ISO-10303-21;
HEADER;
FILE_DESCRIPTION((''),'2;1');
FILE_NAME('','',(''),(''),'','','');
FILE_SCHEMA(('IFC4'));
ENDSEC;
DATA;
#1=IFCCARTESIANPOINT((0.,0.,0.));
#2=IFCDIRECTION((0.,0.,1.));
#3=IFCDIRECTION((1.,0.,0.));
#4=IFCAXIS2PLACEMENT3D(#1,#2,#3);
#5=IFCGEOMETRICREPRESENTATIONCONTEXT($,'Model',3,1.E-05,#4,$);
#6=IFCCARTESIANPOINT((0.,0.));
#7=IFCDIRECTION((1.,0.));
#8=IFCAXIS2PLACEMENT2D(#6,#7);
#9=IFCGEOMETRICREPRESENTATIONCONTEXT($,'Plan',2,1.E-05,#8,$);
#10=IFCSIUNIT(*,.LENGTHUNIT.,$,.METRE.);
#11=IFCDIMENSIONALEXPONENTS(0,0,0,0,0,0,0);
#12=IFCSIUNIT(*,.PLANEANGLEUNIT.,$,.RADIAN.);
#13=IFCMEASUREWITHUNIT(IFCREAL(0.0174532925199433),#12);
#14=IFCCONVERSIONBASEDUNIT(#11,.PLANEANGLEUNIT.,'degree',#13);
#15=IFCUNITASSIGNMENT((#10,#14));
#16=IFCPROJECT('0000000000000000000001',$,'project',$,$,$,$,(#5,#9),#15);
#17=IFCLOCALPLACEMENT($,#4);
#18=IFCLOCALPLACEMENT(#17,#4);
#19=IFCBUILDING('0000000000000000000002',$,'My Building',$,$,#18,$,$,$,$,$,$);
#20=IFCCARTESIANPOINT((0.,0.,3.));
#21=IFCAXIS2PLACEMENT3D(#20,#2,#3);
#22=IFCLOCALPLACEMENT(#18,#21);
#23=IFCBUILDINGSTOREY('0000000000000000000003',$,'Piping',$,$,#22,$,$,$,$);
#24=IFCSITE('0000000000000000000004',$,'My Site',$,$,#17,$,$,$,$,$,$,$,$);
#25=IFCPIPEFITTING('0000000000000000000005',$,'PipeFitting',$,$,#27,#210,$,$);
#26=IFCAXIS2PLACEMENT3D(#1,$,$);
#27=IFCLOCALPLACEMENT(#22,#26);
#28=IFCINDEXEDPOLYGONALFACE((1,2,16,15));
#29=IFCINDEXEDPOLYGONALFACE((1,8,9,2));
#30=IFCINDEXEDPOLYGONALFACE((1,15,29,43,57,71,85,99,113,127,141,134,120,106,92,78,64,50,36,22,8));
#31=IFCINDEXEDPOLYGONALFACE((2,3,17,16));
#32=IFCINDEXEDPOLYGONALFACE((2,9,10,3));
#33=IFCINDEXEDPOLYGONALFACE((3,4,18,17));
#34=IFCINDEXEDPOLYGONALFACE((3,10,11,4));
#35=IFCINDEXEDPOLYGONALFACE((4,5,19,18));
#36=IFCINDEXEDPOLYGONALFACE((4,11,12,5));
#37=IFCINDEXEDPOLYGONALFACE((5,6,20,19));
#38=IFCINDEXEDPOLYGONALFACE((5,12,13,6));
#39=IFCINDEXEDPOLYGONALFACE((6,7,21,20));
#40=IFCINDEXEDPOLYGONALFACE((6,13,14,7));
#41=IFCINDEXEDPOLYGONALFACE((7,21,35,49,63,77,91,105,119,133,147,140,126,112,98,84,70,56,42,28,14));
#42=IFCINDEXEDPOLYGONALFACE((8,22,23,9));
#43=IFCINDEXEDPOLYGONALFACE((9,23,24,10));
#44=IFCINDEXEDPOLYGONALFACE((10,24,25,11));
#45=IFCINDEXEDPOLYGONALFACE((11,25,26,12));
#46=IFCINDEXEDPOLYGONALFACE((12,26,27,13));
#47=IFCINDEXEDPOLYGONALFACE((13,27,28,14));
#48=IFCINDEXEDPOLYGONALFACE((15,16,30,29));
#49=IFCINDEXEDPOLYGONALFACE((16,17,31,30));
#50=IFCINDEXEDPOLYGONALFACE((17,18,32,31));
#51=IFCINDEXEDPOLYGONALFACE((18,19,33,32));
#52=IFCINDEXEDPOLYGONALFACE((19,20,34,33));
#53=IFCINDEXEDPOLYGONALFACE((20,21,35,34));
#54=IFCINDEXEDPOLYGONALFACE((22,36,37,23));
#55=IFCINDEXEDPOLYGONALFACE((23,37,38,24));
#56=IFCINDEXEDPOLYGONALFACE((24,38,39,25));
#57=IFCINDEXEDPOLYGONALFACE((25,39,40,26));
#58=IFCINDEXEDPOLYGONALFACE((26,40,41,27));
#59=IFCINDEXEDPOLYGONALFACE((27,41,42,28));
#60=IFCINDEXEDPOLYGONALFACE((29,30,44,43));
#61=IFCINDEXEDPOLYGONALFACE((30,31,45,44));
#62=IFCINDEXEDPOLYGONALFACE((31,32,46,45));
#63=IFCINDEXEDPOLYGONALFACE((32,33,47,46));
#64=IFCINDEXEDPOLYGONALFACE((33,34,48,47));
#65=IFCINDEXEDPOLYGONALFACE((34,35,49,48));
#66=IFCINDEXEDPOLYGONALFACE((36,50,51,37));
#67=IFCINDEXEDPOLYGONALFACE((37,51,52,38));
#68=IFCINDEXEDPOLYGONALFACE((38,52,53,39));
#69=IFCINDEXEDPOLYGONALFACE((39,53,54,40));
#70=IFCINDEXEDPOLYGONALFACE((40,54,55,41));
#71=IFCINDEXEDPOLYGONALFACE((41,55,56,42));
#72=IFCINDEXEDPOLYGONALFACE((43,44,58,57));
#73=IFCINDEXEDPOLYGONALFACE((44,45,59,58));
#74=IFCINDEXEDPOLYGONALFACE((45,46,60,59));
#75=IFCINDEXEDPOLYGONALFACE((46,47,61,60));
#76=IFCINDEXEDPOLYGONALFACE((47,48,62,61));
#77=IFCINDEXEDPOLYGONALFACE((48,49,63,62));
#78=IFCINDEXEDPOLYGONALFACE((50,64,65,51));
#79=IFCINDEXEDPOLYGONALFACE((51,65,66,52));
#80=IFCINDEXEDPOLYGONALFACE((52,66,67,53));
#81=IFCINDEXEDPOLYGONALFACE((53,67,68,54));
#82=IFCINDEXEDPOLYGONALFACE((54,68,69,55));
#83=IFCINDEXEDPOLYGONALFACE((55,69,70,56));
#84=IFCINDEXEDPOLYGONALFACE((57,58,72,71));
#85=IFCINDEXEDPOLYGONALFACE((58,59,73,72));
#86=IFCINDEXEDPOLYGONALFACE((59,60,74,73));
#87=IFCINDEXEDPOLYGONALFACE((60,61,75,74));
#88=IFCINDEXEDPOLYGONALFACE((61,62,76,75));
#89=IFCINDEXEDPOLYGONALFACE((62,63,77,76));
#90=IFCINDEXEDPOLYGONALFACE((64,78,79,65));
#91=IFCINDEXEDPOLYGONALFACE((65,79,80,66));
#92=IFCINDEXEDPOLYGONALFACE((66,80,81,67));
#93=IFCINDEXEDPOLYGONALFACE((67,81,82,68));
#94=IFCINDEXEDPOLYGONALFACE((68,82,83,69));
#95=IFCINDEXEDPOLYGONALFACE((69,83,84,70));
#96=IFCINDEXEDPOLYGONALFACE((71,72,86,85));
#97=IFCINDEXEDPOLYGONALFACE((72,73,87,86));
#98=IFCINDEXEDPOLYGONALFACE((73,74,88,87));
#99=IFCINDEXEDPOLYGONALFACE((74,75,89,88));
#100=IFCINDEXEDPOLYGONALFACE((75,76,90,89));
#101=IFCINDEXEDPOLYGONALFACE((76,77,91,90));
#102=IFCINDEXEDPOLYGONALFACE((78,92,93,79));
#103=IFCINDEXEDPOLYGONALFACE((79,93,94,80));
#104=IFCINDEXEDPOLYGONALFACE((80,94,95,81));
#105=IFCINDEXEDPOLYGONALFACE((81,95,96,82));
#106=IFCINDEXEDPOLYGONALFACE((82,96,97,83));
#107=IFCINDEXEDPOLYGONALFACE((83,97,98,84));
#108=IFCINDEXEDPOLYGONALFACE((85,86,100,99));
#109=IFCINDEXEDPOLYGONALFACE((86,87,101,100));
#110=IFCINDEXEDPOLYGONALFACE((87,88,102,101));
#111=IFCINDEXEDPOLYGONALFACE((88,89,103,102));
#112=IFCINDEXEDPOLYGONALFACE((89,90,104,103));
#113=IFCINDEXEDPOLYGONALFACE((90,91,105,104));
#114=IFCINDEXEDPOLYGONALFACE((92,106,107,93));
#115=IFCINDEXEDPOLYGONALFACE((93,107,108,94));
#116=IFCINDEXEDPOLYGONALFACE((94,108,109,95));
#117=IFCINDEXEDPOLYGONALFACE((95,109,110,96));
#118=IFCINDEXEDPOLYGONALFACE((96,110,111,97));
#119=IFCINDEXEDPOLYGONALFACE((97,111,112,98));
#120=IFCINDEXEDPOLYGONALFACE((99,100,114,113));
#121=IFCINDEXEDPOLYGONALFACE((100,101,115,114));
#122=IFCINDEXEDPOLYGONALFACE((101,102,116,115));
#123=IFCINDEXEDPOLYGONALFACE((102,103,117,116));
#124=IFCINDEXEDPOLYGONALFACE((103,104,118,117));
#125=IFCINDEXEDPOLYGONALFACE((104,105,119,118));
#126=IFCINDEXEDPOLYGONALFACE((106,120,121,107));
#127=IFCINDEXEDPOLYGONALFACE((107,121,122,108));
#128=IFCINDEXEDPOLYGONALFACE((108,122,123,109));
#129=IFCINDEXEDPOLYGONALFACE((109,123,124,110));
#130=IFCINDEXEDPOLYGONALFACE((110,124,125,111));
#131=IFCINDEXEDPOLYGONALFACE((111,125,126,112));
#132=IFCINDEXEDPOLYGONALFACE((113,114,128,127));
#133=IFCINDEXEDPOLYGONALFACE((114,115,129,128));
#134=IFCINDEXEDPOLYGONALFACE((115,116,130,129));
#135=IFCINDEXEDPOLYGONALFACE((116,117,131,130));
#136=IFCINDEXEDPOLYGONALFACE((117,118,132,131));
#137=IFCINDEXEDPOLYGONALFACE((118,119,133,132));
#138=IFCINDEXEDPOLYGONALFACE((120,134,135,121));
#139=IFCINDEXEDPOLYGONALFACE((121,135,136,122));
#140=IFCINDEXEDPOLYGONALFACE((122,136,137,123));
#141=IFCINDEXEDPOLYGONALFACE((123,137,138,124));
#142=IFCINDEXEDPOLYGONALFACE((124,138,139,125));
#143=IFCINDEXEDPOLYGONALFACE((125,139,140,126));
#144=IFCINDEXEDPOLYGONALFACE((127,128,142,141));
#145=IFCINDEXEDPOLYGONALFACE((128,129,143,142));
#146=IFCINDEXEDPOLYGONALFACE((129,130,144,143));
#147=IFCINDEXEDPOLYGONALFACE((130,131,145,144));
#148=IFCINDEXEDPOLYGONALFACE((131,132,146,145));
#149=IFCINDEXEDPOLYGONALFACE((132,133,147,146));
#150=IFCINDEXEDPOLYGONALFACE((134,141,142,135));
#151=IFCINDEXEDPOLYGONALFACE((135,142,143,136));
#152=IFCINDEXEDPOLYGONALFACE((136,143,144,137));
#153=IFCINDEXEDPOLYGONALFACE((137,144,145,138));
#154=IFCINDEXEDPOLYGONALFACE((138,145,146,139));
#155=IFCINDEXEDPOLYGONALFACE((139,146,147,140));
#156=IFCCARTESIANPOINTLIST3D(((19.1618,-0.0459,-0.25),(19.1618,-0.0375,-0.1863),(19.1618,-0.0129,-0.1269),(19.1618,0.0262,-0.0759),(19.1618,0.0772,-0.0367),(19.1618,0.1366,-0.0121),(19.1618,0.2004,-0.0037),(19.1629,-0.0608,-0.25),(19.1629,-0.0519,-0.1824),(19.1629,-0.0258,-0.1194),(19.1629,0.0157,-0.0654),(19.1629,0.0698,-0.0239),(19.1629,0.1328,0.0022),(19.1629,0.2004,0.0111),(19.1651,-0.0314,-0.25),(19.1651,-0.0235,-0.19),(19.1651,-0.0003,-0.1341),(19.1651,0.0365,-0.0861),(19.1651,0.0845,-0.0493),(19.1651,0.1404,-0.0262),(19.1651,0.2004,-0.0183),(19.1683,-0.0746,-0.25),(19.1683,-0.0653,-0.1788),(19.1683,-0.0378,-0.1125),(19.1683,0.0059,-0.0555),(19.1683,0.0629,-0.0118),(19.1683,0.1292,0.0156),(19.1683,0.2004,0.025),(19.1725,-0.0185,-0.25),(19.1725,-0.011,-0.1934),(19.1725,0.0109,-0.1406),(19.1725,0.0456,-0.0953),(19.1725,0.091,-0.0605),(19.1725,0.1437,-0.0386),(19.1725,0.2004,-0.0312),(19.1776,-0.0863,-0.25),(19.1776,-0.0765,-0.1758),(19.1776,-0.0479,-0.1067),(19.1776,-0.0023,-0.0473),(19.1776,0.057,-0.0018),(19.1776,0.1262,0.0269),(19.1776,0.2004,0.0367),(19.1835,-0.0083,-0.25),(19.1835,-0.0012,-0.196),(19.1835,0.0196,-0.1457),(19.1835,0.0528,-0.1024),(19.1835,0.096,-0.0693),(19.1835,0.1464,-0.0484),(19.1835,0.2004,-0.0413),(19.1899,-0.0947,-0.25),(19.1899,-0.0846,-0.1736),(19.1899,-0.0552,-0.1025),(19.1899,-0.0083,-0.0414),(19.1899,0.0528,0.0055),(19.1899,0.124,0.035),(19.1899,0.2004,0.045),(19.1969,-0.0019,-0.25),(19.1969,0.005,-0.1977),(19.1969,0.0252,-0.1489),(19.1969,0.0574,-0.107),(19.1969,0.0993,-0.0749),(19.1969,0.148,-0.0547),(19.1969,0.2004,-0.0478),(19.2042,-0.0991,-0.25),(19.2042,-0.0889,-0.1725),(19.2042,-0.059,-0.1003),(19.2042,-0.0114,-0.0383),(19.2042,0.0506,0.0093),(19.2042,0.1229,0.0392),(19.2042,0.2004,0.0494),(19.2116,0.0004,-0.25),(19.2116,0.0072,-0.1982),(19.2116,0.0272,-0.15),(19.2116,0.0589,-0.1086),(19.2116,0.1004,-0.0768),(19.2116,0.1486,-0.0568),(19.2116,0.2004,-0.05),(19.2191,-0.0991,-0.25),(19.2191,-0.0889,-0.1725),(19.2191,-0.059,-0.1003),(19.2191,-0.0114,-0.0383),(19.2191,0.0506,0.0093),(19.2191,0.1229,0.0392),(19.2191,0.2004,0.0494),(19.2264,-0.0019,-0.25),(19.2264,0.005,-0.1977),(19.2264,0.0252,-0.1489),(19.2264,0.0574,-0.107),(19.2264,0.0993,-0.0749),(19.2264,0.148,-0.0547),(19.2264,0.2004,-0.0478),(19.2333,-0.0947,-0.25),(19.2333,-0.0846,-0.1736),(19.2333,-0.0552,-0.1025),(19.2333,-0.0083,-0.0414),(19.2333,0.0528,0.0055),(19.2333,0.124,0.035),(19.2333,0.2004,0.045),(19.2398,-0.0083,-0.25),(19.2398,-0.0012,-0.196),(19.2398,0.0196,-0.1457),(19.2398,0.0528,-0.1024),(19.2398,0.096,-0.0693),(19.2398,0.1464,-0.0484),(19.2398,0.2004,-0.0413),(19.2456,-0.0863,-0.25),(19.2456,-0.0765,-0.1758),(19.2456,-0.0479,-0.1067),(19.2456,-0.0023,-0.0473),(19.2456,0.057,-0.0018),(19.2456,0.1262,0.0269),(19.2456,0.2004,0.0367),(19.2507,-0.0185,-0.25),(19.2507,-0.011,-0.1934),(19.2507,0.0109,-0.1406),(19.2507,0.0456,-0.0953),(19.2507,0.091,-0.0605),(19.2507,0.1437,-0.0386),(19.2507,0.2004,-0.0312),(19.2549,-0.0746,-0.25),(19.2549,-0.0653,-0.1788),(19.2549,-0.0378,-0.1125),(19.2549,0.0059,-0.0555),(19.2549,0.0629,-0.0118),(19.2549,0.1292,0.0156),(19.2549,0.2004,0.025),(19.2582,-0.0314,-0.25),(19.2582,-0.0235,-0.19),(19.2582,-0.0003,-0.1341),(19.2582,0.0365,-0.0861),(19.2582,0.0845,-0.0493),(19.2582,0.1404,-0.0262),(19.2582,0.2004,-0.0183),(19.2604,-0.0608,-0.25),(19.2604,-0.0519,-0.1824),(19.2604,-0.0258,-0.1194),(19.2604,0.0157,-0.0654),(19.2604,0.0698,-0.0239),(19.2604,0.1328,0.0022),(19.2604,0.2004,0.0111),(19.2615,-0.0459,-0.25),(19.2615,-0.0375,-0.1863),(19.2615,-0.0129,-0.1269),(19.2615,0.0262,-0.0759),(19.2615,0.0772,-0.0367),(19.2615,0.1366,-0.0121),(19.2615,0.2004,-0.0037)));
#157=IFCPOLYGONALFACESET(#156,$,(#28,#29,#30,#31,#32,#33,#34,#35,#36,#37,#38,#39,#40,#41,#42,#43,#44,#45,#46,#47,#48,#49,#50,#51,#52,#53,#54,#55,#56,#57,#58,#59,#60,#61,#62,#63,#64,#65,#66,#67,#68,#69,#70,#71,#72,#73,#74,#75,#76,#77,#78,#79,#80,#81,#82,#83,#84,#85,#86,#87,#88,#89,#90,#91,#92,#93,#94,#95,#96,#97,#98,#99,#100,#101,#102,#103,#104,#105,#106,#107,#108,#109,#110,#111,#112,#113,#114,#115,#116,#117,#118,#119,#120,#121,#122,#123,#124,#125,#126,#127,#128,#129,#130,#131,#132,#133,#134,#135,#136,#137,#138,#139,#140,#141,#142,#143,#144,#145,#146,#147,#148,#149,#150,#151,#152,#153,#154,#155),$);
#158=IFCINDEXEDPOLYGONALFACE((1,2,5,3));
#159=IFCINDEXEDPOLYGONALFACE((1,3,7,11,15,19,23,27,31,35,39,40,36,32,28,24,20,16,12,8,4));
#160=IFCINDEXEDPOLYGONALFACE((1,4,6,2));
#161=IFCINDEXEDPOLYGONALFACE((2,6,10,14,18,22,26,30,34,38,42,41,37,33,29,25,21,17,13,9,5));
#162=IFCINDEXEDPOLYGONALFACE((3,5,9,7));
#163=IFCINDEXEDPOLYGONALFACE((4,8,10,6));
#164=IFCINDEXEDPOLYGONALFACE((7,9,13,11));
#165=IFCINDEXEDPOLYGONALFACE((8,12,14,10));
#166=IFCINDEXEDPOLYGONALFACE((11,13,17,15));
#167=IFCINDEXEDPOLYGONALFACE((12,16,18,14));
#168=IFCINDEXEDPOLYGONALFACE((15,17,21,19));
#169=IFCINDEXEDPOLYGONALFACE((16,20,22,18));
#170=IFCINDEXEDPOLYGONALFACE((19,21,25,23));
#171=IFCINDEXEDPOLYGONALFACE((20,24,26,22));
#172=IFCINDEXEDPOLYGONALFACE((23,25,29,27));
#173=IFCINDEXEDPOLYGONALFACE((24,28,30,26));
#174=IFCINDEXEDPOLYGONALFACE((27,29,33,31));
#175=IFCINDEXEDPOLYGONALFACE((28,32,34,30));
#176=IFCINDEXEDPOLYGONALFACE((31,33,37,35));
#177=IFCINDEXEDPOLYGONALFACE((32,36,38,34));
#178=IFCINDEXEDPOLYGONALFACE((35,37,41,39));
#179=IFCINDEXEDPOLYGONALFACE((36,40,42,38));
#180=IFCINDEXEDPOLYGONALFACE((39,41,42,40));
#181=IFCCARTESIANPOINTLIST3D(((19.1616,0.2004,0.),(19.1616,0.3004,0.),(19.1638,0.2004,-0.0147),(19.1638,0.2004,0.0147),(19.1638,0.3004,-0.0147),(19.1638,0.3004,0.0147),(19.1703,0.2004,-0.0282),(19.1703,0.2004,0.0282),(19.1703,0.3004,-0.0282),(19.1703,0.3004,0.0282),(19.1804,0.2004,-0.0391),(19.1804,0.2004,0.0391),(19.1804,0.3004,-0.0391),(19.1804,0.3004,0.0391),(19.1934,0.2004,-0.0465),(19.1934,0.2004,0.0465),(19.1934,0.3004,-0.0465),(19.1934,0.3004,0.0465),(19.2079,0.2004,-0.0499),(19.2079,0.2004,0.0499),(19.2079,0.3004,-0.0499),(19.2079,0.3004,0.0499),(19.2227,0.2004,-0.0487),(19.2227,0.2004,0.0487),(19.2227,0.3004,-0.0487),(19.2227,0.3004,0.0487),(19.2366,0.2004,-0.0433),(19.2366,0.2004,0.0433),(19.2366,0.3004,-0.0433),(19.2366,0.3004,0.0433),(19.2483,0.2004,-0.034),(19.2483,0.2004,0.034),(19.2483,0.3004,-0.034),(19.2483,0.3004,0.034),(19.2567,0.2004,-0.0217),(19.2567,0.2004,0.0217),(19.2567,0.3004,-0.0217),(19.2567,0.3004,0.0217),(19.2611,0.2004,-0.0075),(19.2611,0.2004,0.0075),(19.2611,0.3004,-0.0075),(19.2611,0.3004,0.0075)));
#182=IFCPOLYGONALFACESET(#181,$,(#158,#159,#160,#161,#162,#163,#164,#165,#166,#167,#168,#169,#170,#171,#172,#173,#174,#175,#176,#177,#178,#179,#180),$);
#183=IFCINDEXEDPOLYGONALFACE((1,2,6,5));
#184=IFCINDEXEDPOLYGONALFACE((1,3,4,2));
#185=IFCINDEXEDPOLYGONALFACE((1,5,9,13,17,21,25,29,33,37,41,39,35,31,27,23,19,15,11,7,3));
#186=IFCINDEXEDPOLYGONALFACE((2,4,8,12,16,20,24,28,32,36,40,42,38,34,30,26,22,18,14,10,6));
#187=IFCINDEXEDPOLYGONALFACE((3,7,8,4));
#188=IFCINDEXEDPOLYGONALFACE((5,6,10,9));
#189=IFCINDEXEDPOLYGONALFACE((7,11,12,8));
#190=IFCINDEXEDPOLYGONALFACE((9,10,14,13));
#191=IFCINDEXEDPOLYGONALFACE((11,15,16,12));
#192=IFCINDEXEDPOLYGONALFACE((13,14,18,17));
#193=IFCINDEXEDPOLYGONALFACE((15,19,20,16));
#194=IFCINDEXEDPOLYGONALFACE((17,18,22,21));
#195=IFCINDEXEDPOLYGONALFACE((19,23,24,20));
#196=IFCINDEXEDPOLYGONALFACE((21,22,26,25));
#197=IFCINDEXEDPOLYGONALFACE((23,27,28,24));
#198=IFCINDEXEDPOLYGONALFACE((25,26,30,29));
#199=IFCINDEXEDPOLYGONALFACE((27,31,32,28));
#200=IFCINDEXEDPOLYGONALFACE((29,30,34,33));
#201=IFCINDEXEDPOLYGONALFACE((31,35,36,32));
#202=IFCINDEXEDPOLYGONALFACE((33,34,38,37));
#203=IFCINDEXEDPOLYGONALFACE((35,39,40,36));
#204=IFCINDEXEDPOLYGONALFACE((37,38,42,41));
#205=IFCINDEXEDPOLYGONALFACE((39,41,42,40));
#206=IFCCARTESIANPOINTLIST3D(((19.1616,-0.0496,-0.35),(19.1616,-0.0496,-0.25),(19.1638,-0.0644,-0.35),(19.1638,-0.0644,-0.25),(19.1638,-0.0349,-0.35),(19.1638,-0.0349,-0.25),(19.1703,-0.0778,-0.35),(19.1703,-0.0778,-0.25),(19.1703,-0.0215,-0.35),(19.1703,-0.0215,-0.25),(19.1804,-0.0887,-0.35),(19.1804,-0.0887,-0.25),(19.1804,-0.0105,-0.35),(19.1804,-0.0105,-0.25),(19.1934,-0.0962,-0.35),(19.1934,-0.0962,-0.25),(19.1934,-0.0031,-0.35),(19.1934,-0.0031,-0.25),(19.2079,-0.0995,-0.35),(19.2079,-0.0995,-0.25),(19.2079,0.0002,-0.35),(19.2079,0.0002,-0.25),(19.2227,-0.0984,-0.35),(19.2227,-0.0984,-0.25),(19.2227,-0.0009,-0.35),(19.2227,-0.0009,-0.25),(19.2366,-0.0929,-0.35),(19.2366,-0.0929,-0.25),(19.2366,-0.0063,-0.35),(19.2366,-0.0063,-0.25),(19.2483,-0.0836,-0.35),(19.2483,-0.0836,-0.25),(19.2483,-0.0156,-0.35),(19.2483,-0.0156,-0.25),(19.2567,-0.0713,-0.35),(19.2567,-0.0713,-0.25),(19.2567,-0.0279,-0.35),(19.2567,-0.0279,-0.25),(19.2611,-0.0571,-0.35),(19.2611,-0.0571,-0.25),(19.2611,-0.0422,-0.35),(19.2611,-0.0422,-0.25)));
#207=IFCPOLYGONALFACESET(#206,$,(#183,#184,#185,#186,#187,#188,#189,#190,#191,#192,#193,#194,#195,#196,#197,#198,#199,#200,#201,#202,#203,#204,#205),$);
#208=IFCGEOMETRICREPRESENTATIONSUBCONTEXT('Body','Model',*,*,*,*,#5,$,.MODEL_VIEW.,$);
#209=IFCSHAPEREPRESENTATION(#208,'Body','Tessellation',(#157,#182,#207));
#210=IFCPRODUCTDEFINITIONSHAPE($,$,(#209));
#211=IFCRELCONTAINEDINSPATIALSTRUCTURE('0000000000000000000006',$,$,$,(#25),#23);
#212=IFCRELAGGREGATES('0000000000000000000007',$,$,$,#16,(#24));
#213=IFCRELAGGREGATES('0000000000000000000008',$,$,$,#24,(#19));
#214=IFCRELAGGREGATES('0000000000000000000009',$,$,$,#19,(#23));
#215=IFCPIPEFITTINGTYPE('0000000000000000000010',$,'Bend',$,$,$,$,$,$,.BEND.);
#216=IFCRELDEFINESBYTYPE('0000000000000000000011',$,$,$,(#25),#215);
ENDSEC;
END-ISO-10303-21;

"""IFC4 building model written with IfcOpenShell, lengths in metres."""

from ifc_helpers import new_model, entity, si_unit, converted_unit, frame, origin_with_axes, origin_2d_with_axis, place, context, subcontext, project, spatial, circle, extrude, source, transform, mapped, type_object, type_shapes, element, save


model = new_model("IFC4")

# Units and contexts
model_context = context("Model", 3, precision=1e-05, world=origin_with_axes())
plan_context = context("Plan", 2, precision=1e-05, world=origin_2d_with_axis())
body_context = subcontext(model_context, "Body", "Model", "MODEL_VIEW")
ifc_project = project(units=[si_unit("LENGTHUNIT", "METRE"), converted_unit("PLANEANGLEUNIT", "degree", entity("IfcReal", 0.0174532925199433), si_unit("PLANEANGLEUNIT", "RADIAN"), dimensions=[0, 0, 0, 0, 0, 0, 0])], contexts=[model_context, plan_context])

# Site, building, storey
site_placement = place(None, origin_with_axes())
site = spatial("IfcSite", under=ifc_project, at=site_placement, Name="My Site")
building_placement = place(site_placement, origin_with_axes())
building = spatial("IfcBuilding", under=site, at=building_placement, Name="My Building")
storey_placement = place(building_placement, frame((0.0, 0.0, 3.0), z_axis=(0.0, 0.0, 1.0), x_axis=(1.0, 0.0, 0.0)))
storey = spatial("IfcBuildingStorey", under=building, at=storey_placement, Name="Piping")

# Pipe fitting
pipe_fitting_type = type_object("IfcPipeFittingType", Name="Bend", PredefinedType="BEND")
shared_shape = source(origin_with_axes(), body_context, "Body", "SolidModel", [
    entity("IfcSweptDiskSolid", entity("IfcIndexedPolyCurve", entity("IfcCartesianPointList3D", [[0.0, 0.0, -0.1], [0.0, -0.0732, -0.2768], [0.0, -0.25, -0.35]]), [entity("IfcArcIndex", [1, 2, 3])]), 0.05),
    extrude(circle(Radius=0.05), origin_with_axes(), (0.0, 0.0, -1.0), 0.1),
    extrude(circle(Radius=0.05), frame((0.0, -0.25, -0.35), z_axis=(0.0, -1.0, 0.0), x_axis=(1.0, 0.0, 0.0)), (0.0, 0.0, 1.0), 0.1),
])
type_shapes(pipe_fitting_type, [shared_shape])
for number, where, z_axis, x_axis, name in (
    (1, (19.2116, 0.3004, 0.0), (0.0, 1.0, 0.0), (-1.0, 0.0, 0.0), "PipeFitting"),
):
    element("IfcPipeFitting", number, at=place(storey_placement, frame(where, z_axis=z_axis, x_axis=x_axis)), inside=storey, type_object=pipe_fitting_type, Name=name, context=body_context, shape_type="MappedRepresentation", body=[
        mapped(shared_shape, transform((0.0, 0.0, 0.0), x_axis=(1.0, 0.0, 0.0), y_axis=(0.0, 1.0, 0.0), z_axis=(0.0, 0.0, 1.0), scale=1.0)),
    ])

save(model, "model.ifc")
